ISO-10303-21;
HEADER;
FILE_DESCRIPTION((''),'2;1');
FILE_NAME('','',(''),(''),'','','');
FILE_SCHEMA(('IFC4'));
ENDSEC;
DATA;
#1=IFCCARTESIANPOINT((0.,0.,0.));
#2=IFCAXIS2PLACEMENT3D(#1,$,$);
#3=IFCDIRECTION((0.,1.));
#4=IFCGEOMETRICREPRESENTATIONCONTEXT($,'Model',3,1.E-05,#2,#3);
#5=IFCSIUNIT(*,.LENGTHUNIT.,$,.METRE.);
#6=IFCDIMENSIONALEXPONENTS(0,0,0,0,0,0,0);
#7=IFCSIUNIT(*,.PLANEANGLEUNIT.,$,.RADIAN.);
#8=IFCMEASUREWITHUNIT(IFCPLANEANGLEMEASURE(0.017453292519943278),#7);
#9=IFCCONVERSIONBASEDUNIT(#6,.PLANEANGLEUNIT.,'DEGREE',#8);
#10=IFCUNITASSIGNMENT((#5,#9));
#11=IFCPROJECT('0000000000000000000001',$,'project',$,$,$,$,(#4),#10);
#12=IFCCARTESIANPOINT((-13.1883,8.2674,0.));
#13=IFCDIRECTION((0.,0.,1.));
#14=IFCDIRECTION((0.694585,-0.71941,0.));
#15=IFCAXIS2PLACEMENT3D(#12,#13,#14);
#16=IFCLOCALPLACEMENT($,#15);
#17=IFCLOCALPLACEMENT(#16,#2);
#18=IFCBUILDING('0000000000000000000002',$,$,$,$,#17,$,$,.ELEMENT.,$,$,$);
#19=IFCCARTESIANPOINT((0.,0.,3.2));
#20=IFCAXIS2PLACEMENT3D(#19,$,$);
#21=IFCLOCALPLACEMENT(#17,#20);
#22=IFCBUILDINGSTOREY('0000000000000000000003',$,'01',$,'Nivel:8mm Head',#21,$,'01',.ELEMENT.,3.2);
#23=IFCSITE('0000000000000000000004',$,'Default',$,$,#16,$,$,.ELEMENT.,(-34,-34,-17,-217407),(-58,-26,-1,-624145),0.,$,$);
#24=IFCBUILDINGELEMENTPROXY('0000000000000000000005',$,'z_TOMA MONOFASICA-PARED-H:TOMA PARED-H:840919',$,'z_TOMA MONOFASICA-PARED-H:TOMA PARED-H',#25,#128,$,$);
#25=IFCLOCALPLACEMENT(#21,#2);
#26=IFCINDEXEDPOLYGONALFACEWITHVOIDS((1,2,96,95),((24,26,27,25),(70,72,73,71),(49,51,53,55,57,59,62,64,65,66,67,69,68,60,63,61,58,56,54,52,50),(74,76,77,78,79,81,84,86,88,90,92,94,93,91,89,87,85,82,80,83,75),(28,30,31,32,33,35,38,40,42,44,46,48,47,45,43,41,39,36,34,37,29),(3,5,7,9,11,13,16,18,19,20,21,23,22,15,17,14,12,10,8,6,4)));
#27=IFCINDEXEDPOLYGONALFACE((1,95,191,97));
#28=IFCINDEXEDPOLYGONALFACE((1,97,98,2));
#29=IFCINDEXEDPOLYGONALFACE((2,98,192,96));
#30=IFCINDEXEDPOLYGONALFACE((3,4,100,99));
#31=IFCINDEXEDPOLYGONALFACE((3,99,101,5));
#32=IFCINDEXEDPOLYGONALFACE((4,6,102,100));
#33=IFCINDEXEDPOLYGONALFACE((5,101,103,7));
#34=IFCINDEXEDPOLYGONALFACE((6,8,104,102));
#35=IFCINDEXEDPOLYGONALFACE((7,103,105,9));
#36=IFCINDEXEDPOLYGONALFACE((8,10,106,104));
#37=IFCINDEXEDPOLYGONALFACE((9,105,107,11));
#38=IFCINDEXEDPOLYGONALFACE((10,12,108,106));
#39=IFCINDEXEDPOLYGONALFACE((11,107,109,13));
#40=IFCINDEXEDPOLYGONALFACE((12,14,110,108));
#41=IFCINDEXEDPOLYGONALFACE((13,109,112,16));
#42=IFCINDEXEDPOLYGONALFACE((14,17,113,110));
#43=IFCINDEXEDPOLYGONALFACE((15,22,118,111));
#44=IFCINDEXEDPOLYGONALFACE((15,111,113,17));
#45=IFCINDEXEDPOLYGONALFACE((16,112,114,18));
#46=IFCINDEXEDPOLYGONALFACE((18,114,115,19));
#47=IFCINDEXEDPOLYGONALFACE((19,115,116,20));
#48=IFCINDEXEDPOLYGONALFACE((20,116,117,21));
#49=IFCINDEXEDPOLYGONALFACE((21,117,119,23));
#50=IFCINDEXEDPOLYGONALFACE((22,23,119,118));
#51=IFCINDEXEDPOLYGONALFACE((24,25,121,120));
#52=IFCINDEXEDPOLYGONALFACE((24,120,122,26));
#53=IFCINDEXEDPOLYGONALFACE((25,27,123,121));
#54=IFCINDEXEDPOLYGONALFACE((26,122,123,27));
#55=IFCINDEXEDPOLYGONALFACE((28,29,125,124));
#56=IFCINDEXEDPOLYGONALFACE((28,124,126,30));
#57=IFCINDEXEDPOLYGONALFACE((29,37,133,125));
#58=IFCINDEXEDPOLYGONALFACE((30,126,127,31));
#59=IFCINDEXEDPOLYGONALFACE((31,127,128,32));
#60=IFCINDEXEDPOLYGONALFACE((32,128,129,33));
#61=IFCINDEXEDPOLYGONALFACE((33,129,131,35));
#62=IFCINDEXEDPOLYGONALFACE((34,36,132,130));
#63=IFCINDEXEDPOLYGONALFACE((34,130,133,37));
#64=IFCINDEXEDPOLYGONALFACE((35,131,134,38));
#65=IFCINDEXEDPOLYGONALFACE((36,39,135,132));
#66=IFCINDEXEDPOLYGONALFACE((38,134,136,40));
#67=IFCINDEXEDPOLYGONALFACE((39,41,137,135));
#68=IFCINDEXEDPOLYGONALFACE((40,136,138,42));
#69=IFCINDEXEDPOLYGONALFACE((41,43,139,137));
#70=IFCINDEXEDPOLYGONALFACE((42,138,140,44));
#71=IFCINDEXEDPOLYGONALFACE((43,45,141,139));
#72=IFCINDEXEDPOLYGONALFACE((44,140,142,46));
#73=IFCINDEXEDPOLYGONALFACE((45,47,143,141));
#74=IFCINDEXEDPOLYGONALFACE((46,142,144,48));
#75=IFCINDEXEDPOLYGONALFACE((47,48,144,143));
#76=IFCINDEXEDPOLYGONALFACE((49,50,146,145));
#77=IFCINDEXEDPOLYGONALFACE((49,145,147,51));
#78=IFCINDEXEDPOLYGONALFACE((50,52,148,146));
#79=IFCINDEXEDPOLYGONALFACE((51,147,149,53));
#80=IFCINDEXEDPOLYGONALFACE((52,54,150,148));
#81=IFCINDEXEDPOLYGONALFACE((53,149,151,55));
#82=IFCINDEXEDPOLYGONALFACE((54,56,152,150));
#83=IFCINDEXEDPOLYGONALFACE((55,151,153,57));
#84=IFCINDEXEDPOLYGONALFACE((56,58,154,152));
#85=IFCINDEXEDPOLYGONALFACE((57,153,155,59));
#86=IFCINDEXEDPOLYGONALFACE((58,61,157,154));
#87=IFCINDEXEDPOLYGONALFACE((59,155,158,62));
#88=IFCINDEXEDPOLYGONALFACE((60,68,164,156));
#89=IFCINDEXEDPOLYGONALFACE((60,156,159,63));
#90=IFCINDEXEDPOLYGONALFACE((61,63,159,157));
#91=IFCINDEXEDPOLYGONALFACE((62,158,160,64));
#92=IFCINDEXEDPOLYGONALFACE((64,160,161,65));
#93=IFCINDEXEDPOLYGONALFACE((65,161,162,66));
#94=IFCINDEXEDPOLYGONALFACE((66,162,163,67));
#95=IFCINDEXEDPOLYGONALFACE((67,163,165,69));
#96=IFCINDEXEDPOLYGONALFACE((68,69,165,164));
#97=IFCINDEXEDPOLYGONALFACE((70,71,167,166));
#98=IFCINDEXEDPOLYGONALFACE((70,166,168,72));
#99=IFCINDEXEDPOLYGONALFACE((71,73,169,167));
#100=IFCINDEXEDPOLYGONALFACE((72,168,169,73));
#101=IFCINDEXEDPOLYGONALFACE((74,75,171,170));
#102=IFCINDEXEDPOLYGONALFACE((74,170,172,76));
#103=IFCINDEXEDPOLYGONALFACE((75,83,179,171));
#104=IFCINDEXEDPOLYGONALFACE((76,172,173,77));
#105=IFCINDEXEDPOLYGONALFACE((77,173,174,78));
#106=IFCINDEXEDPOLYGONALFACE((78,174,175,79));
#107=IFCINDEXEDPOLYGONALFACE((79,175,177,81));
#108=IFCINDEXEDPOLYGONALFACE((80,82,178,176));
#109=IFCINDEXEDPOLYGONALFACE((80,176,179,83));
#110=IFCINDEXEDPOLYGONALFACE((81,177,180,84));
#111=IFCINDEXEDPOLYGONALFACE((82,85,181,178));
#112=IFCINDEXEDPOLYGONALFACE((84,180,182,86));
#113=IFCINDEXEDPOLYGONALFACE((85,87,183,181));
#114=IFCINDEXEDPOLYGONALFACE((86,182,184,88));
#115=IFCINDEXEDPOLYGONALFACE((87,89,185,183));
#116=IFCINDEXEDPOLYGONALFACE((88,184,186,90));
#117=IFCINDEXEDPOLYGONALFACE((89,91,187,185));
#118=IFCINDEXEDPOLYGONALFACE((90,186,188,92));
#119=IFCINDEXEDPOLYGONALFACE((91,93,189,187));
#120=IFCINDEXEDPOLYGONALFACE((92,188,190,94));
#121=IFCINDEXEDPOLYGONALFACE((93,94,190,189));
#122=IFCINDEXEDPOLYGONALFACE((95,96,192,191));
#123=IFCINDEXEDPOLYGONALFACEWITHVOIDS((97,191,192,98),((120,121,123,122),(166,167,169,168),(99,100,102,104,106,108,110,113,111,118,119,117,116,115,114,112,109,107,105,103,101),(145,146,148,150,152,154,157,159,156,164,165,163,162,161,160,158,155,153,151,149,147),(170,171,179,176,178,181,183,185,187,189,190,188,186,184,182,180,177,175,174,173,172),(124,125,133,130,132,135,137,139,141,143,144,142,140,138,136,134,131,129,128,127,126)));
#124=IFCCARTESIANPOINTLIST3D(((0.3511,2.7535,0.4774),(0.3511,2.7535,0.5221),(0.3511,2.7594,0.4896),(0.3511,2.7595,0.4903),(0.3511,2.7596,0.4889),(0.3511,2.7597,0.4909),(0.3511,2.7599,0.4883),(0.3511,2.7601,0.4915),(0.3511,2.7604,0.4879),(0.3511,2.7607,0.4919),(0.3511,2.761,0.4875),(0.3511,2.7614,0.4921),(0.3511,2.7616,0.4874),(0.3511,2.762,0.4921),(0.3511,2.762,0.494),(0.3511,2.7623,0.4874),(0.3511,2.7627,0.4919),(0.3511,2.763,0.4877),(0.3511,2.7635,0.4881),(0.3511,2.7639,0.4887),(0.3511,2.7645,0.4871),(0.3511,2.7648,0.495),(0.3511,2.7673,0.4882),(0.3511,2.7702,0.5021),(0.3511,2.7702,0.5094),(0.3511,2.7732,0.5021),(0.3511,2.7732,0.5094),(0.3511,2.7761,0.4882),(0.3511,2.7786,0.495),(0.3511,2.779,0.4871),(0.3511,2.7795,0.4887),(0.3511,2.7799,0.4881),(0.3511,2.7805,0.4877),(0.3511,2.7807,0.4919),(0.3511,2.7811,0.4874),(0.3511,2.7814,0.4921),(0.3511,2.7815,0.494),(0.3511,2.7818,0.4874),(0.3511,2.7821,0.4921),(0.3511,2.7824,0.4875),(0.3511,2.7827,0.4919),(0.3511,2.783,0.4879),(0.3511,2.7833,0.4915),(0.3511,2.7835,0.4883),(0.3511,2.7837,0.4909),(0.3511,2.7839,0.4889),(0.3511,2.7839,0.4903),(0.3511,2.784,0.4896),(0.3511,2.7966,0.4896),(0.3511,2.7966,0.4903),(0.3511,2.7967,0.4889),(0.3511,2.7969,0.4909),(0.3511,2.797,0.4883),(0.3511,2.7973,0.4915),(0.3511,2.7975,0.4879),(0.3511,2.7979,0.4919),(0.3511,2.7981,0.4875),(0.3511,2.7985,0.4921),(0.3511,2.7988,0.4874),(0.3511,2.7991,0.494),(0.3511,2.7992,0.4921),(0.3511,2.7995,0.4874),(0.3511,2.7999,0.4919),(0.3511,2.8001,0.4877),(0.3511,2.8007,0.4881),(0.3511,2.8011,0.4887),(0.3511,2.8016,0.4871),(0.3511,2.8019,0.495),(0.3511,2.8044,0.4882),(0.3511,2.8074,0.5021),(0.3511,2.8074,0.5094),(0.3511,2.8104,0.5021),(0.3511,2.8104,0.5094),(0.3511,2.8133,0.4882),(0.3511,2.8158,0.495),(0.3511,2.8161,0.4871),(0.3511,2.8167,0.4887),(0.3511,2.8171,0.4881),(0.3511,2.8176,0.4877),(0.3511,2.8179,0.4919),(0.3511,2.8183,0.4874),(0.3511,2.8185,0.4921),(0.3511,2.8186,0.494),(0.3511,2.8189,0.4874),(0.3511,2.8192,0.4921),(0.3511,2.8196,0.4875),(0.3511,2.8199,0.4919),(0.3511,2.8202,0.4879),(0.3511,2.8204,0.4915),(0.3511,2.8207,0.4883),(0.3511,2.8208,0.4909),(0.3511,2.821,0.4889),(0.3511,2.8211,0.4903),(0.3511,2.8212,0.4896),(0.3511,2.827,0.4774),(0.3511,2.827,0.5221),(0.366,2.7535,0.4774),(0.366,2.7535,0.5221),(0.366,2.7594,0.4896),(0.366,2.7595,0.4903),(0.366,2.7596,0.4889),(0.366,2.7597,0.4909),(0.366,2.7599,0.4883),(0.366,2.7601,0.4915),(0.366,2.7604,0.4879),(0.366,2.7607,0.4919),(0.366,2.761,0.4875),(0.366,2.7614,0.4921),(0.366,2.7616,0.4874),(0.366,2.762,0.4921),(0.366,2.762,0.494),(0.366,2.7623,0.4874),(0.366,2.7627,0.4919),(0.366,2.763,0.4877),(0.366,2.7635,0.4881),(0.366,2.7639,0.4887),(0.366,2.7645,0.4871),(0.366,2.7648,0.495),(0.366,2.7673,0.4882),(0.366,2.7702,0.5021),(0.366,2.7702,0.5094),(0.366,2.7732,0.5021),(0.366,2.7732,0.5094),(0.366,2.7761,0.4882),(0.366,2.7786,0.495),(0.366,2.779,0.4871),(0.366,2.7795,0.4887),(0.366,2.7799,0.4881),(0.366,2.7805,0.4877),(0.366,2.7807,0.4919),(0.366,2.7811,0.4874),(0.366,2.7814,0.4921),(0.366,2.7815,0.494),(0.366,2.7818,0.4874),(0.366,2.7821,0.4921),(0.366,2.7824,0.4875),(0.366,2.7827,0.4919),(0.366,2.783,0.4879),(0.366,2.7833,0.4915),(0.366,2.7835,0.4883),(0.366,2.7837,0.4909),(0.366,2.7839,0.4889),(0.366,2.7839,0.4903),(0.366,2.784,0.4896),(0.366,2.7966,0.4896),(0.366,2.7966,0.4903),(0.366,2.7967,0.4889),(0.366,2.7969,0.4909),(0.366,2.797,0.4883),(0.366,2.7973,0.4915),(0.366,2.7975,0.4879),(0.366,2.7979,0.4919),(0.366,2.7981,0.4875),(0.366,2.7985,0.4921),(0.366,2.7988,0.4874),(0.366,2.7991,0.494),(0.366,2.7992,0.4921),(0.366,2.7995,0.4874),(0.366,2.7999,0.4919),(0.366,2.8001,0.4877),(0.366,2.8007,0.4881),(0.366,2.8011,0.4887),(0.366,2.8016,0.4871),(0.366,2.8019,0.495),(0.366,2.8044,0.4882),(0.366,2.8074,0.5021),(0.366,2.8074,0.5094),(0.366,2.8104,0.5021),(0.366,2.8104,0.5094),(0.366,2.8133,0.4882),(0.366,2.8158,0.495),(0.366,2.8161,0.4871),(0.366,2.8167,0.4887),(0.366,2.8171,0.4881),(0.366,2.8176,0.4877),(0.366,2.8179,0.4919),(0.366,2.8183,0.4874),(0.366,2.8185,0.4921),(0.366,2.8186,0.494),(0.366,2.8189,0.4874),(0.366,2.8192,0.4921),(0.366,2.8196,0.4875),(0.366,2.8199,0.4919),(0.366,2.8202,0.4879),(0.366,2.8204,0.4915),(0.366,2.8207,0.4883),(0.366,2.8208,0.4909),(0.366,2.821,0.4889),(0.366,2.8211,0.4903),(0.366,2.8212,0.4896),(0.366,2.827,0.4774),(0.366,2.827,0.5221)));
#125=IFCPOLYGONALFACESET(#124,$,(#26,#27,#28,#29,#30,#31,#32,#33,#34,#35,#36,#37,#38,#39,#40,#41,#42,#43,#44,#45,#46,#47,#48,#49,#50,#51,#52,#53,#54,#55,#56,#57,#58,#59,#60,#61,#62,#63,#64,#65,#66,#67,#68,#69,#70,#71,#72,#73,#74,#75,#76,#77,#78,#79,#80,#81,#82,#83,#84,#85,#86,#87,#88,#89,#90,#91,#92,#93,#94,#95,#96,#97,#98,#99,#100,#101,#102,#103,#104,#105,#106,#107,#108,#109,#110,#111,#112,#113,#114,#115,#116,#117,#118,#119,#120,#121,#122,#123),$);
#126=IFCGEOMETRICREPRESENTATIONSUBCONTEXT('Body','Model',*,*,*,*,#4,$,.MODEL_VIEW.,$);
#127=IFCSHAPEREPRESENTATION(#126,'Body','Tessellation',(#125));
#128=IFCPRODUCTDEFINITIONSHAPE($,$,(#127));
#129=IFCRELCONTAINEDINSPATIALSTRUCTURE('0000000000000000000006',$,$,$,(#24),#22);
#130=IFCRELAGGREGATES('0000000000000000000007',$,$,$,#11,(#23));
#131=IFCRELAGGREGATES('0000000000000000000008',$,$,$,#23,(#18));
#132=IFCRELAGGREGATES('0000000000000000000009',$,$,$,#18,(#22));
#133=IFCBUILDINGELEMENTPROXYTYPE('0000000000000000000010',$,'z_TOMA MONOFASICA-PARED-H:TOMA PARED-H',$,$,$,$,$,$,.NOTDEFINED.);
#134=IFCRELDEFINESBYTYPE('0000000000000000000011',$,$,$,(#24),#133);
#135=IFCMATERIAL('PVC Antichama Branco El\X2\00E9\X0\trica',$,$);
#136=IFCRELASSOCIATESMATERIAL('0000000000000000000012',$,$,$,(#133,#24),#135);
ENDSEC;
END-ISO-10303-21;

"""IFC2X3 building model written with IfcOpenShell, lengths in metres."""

from ifc_helpers import new_model, entity, si_unit, converted_unit, direction, frame, frame_2d, origin, place, context, subcontext, project, spatial, polyline, circle_curve, parameter, trimmed, segment, composite_curve, outline, extrude, source, transform, mapped, material, type_object, type_shapes, element, save


model = new_model("IFC2X3")

# Units and contexts
model_context = context("Model", 3, precision=1e-05, world=origin(), true_north=direction((0.0, 1.0)))
body_context = subcontext(model_context, "Body", "Model", "MODEL_VIEW")
ifc_project = project(units=[si_unit("LENGTHUNIT", "METRE"), converted_unit("PLANEANGLEUNIT", "DEGREE", entity("IfcPlaneAngleMeasure", 0.017453292519943278), si_unit("PLANEANGLEUNIT", "RADIAN"), dimensions=[0, 0, 0, 0, 0, 0, 0])], contexts=[model_context])

# Site, building, storey
site_placement = place(None, frame((-13.1883, 8.2674, 0.0), z_axis=(0.0, 0.0, 1.0), x_axis=(0.694585, -0.71941, 0.0)))
site = spatial("IfcSite", under=ifc_project, at=site_placement, Name="Default", CompositionType="ELEMENT", RefLatitude=(-34, -34, -17, -217407), RefLongitude=(-58, -26, -1, -624145), RefElevation=0.0)
building_placement = place(site_placement, origin())
building = spatial("IfcBuilding", under=site, at=building_placement, CompositionType="ELEMENT")
storey_placement = place(building_placement, frame((0.0, 0.0, 3.2)))
storey = spatial("IfcBuildingStorey", under=building, at=storey_placement, Name="01", ObjectType="Nivel:8mm Head", LongName="01", CompositionType="ELEMENT", Elevation=3.2)

# Building element proxy
ifc_material_1 = material(Name="PVC Antichama Branco Elétrica")
building_element_proxy_type_1 = type_object("IfcBuildingElementProxyType", Name="z_TOMA MONOFASICA-PARED-H:TOMA PARED-H", PredefinedType="NOTDEFINED", material=ifc_material_1)
shared_shape_1 = source(origin(), body_context, "Body", "SweptSolid", [
    extrude(outline(polyline([(-0.0368, -0.0223), (0.0368, -0.0223), (0.0368, 0.0223), (-0.0368, 0.0223), (-0.0368, -0.0223)]), holes=[composite_curve([segment(polyline([(0.0141, 0.0115), (0.0116, 0.0047)]), True, "CONTINUOUS"), segment(polyline([(0.0116, 0.0047), (0.0088, 0.0057)]), True, "CONTINUOUS"), segment(polyline([(0.0088, 0.0057), (0.0096, 0.0078)]), True, "CONTINUOUS"), segment(trimmed(circle_curve(frame_2d((0.0087, 0.0099), x_axis=(1.0, 0.0)), 0.0024), [parameter(27.118901)], [parameter(292.881099)], True, "PARAMETER"), False, "CONTINUOUS"), segment(polyline([(0.0108, 0.011), (0.0113, 0.0126)]), True, "CONTINUOUS"), segment(polyline([(0.0113, 0.0126), (0.0141, 0.0115)]), True, "CONTINUOUS")], self_intersect=False), composite_curve([segment(polyline([(0.0255, 0.0047), (0.023, 0.0115)]), True, "CONTINUOUS"), segment(polyline([(0.023, 0.0115), (0.0258, 0.0126)]), True, "CONTINUOUS"), segment(polyline([(0.0258, 0.0126), (0.0264, 0.011)]), True, "CONTINUOUS"), segment(trimmed(circle_curve(frame_2d((0.0285, 0.0099), x_axis=(1.0, 0.0)), 0.0024), [parameter(247.118901)], [parameter(152.881099)], True, "PARAMETER"), False, "CONTINUOUS"), segment(polyline([(0.0276, 0.0078), (0.0283, 0.0057)]), True, "CONTINUOUS"), segment(polyline([(0.0283, 0.0057), (0.0255, 0.0047)]), True, "CONTINUOUS")], self_intersect=False), polyline([(0.0201, -0.0024), (0.0201, -0.0097), (0.0171, -0.0097), (0.0171, -0.0024), (0.0201, -0.0024)]), composite_curve([segment(polyline([(-0.0141, 0.0115), (-0.0113, 0.0126)]), True, "CONTINUOUS"), segment(polyline([(-0.0113, 0.0126), (-0.0108, 0.011)]), True, "CONTINUOUS"), segment(trimmed(circle_curve(frame_2d((-0.0087, 0.0099), x_axis=(1.0, 0.0)), 0.0024), [parameter(247.118901)], [parameter(152.881099)], True, "PARAMETER"), False, "CONTINUOUS"), segment(polyline([(-0.0096, 0.0078), (-0.0088, 0.0057)]), True, "CONTINUOUS"), segment(polyline([(-0.0088, 0.0057), (-0.0116, 0.0047)]), True, "CONTINUOUS"), segment(polyline([(-0.0116, 0.0047), (-0.0141, 0.0115)]), True, "CONTINUOUS")], self_intersect=False), composite_curve([segment(polyline([(-0.0255, 0.0047), (-0.0283, 0.0057)]), True, "CONTINUOUS"), segment(polyline([(-0.0283, 0.0057), (-0.0276, 0.0078)]), True, "CONTINUOUS"), segment(trimmed(circle_curve(frame_2d((-0.0285, 0.0099), x_axis=(1.0, 0.0)), 0.0024), [parameter(27.118901)], [parameter(292.881099)], True, "PARAMETER"), False, "CONTINUOUS"), segment(polyline([(-0.0264, 0.011), (-0.0258, 0.0126)]), True, "CONTINUOUS"), segment(polyline([(-0.0258, 0.0126), (-0.023, 0.0115)]), True, "CONTINUOUS"), segment(polyline([(-0.023, 0.0115), (-0.0255, 0.0047)]), True, "CONTINUOUS")], self_intersect=False), polyline([(-0.0201, -0.0024), (-0.0171, -0.0024), (-0.0171, -0.0097), (-0.0201, -0.0097), (-0.0201, -0.0024)])]), frame((0.0, -0.005, 0.0223), z_axis=(0.0, 1.0, 0.0), x_axis=(1.0, 0.0, 0.0)), (0.0, 0.0, 1.0), 0.0148),
])
type_shapes(building_element_proxy_type_1, [shared_shape_1])
for number, where, z_axis, x_axis, name in (
    (1, (0.361, 2.7903, 0.4774), (0.0, 0.0, 1.0), (0.0, 1.0, 0.0), "z_TOMA MONOFASICA-PARED-H:TOMA PARED-H:840919"),
):
    element("IfcBuildingElementProxy", number, at=place(storey_placement, frame(where, z_axis=z_axis, x_axis=x_axis)), inside=storey, type_object=building_element_proxy_type_1, material=ifc_material_1, Name=name, ObjectType="z_TOMA MONOFASICA-PARED-H:TOMA PARED-H", context=body_context, shape_type="MappedRepresentation", body=[
        mapped(shared_shape_1, transform((0.0, 0.0, 0.0), scale=1.0)),
    ])

save(model, "model.ifc")
